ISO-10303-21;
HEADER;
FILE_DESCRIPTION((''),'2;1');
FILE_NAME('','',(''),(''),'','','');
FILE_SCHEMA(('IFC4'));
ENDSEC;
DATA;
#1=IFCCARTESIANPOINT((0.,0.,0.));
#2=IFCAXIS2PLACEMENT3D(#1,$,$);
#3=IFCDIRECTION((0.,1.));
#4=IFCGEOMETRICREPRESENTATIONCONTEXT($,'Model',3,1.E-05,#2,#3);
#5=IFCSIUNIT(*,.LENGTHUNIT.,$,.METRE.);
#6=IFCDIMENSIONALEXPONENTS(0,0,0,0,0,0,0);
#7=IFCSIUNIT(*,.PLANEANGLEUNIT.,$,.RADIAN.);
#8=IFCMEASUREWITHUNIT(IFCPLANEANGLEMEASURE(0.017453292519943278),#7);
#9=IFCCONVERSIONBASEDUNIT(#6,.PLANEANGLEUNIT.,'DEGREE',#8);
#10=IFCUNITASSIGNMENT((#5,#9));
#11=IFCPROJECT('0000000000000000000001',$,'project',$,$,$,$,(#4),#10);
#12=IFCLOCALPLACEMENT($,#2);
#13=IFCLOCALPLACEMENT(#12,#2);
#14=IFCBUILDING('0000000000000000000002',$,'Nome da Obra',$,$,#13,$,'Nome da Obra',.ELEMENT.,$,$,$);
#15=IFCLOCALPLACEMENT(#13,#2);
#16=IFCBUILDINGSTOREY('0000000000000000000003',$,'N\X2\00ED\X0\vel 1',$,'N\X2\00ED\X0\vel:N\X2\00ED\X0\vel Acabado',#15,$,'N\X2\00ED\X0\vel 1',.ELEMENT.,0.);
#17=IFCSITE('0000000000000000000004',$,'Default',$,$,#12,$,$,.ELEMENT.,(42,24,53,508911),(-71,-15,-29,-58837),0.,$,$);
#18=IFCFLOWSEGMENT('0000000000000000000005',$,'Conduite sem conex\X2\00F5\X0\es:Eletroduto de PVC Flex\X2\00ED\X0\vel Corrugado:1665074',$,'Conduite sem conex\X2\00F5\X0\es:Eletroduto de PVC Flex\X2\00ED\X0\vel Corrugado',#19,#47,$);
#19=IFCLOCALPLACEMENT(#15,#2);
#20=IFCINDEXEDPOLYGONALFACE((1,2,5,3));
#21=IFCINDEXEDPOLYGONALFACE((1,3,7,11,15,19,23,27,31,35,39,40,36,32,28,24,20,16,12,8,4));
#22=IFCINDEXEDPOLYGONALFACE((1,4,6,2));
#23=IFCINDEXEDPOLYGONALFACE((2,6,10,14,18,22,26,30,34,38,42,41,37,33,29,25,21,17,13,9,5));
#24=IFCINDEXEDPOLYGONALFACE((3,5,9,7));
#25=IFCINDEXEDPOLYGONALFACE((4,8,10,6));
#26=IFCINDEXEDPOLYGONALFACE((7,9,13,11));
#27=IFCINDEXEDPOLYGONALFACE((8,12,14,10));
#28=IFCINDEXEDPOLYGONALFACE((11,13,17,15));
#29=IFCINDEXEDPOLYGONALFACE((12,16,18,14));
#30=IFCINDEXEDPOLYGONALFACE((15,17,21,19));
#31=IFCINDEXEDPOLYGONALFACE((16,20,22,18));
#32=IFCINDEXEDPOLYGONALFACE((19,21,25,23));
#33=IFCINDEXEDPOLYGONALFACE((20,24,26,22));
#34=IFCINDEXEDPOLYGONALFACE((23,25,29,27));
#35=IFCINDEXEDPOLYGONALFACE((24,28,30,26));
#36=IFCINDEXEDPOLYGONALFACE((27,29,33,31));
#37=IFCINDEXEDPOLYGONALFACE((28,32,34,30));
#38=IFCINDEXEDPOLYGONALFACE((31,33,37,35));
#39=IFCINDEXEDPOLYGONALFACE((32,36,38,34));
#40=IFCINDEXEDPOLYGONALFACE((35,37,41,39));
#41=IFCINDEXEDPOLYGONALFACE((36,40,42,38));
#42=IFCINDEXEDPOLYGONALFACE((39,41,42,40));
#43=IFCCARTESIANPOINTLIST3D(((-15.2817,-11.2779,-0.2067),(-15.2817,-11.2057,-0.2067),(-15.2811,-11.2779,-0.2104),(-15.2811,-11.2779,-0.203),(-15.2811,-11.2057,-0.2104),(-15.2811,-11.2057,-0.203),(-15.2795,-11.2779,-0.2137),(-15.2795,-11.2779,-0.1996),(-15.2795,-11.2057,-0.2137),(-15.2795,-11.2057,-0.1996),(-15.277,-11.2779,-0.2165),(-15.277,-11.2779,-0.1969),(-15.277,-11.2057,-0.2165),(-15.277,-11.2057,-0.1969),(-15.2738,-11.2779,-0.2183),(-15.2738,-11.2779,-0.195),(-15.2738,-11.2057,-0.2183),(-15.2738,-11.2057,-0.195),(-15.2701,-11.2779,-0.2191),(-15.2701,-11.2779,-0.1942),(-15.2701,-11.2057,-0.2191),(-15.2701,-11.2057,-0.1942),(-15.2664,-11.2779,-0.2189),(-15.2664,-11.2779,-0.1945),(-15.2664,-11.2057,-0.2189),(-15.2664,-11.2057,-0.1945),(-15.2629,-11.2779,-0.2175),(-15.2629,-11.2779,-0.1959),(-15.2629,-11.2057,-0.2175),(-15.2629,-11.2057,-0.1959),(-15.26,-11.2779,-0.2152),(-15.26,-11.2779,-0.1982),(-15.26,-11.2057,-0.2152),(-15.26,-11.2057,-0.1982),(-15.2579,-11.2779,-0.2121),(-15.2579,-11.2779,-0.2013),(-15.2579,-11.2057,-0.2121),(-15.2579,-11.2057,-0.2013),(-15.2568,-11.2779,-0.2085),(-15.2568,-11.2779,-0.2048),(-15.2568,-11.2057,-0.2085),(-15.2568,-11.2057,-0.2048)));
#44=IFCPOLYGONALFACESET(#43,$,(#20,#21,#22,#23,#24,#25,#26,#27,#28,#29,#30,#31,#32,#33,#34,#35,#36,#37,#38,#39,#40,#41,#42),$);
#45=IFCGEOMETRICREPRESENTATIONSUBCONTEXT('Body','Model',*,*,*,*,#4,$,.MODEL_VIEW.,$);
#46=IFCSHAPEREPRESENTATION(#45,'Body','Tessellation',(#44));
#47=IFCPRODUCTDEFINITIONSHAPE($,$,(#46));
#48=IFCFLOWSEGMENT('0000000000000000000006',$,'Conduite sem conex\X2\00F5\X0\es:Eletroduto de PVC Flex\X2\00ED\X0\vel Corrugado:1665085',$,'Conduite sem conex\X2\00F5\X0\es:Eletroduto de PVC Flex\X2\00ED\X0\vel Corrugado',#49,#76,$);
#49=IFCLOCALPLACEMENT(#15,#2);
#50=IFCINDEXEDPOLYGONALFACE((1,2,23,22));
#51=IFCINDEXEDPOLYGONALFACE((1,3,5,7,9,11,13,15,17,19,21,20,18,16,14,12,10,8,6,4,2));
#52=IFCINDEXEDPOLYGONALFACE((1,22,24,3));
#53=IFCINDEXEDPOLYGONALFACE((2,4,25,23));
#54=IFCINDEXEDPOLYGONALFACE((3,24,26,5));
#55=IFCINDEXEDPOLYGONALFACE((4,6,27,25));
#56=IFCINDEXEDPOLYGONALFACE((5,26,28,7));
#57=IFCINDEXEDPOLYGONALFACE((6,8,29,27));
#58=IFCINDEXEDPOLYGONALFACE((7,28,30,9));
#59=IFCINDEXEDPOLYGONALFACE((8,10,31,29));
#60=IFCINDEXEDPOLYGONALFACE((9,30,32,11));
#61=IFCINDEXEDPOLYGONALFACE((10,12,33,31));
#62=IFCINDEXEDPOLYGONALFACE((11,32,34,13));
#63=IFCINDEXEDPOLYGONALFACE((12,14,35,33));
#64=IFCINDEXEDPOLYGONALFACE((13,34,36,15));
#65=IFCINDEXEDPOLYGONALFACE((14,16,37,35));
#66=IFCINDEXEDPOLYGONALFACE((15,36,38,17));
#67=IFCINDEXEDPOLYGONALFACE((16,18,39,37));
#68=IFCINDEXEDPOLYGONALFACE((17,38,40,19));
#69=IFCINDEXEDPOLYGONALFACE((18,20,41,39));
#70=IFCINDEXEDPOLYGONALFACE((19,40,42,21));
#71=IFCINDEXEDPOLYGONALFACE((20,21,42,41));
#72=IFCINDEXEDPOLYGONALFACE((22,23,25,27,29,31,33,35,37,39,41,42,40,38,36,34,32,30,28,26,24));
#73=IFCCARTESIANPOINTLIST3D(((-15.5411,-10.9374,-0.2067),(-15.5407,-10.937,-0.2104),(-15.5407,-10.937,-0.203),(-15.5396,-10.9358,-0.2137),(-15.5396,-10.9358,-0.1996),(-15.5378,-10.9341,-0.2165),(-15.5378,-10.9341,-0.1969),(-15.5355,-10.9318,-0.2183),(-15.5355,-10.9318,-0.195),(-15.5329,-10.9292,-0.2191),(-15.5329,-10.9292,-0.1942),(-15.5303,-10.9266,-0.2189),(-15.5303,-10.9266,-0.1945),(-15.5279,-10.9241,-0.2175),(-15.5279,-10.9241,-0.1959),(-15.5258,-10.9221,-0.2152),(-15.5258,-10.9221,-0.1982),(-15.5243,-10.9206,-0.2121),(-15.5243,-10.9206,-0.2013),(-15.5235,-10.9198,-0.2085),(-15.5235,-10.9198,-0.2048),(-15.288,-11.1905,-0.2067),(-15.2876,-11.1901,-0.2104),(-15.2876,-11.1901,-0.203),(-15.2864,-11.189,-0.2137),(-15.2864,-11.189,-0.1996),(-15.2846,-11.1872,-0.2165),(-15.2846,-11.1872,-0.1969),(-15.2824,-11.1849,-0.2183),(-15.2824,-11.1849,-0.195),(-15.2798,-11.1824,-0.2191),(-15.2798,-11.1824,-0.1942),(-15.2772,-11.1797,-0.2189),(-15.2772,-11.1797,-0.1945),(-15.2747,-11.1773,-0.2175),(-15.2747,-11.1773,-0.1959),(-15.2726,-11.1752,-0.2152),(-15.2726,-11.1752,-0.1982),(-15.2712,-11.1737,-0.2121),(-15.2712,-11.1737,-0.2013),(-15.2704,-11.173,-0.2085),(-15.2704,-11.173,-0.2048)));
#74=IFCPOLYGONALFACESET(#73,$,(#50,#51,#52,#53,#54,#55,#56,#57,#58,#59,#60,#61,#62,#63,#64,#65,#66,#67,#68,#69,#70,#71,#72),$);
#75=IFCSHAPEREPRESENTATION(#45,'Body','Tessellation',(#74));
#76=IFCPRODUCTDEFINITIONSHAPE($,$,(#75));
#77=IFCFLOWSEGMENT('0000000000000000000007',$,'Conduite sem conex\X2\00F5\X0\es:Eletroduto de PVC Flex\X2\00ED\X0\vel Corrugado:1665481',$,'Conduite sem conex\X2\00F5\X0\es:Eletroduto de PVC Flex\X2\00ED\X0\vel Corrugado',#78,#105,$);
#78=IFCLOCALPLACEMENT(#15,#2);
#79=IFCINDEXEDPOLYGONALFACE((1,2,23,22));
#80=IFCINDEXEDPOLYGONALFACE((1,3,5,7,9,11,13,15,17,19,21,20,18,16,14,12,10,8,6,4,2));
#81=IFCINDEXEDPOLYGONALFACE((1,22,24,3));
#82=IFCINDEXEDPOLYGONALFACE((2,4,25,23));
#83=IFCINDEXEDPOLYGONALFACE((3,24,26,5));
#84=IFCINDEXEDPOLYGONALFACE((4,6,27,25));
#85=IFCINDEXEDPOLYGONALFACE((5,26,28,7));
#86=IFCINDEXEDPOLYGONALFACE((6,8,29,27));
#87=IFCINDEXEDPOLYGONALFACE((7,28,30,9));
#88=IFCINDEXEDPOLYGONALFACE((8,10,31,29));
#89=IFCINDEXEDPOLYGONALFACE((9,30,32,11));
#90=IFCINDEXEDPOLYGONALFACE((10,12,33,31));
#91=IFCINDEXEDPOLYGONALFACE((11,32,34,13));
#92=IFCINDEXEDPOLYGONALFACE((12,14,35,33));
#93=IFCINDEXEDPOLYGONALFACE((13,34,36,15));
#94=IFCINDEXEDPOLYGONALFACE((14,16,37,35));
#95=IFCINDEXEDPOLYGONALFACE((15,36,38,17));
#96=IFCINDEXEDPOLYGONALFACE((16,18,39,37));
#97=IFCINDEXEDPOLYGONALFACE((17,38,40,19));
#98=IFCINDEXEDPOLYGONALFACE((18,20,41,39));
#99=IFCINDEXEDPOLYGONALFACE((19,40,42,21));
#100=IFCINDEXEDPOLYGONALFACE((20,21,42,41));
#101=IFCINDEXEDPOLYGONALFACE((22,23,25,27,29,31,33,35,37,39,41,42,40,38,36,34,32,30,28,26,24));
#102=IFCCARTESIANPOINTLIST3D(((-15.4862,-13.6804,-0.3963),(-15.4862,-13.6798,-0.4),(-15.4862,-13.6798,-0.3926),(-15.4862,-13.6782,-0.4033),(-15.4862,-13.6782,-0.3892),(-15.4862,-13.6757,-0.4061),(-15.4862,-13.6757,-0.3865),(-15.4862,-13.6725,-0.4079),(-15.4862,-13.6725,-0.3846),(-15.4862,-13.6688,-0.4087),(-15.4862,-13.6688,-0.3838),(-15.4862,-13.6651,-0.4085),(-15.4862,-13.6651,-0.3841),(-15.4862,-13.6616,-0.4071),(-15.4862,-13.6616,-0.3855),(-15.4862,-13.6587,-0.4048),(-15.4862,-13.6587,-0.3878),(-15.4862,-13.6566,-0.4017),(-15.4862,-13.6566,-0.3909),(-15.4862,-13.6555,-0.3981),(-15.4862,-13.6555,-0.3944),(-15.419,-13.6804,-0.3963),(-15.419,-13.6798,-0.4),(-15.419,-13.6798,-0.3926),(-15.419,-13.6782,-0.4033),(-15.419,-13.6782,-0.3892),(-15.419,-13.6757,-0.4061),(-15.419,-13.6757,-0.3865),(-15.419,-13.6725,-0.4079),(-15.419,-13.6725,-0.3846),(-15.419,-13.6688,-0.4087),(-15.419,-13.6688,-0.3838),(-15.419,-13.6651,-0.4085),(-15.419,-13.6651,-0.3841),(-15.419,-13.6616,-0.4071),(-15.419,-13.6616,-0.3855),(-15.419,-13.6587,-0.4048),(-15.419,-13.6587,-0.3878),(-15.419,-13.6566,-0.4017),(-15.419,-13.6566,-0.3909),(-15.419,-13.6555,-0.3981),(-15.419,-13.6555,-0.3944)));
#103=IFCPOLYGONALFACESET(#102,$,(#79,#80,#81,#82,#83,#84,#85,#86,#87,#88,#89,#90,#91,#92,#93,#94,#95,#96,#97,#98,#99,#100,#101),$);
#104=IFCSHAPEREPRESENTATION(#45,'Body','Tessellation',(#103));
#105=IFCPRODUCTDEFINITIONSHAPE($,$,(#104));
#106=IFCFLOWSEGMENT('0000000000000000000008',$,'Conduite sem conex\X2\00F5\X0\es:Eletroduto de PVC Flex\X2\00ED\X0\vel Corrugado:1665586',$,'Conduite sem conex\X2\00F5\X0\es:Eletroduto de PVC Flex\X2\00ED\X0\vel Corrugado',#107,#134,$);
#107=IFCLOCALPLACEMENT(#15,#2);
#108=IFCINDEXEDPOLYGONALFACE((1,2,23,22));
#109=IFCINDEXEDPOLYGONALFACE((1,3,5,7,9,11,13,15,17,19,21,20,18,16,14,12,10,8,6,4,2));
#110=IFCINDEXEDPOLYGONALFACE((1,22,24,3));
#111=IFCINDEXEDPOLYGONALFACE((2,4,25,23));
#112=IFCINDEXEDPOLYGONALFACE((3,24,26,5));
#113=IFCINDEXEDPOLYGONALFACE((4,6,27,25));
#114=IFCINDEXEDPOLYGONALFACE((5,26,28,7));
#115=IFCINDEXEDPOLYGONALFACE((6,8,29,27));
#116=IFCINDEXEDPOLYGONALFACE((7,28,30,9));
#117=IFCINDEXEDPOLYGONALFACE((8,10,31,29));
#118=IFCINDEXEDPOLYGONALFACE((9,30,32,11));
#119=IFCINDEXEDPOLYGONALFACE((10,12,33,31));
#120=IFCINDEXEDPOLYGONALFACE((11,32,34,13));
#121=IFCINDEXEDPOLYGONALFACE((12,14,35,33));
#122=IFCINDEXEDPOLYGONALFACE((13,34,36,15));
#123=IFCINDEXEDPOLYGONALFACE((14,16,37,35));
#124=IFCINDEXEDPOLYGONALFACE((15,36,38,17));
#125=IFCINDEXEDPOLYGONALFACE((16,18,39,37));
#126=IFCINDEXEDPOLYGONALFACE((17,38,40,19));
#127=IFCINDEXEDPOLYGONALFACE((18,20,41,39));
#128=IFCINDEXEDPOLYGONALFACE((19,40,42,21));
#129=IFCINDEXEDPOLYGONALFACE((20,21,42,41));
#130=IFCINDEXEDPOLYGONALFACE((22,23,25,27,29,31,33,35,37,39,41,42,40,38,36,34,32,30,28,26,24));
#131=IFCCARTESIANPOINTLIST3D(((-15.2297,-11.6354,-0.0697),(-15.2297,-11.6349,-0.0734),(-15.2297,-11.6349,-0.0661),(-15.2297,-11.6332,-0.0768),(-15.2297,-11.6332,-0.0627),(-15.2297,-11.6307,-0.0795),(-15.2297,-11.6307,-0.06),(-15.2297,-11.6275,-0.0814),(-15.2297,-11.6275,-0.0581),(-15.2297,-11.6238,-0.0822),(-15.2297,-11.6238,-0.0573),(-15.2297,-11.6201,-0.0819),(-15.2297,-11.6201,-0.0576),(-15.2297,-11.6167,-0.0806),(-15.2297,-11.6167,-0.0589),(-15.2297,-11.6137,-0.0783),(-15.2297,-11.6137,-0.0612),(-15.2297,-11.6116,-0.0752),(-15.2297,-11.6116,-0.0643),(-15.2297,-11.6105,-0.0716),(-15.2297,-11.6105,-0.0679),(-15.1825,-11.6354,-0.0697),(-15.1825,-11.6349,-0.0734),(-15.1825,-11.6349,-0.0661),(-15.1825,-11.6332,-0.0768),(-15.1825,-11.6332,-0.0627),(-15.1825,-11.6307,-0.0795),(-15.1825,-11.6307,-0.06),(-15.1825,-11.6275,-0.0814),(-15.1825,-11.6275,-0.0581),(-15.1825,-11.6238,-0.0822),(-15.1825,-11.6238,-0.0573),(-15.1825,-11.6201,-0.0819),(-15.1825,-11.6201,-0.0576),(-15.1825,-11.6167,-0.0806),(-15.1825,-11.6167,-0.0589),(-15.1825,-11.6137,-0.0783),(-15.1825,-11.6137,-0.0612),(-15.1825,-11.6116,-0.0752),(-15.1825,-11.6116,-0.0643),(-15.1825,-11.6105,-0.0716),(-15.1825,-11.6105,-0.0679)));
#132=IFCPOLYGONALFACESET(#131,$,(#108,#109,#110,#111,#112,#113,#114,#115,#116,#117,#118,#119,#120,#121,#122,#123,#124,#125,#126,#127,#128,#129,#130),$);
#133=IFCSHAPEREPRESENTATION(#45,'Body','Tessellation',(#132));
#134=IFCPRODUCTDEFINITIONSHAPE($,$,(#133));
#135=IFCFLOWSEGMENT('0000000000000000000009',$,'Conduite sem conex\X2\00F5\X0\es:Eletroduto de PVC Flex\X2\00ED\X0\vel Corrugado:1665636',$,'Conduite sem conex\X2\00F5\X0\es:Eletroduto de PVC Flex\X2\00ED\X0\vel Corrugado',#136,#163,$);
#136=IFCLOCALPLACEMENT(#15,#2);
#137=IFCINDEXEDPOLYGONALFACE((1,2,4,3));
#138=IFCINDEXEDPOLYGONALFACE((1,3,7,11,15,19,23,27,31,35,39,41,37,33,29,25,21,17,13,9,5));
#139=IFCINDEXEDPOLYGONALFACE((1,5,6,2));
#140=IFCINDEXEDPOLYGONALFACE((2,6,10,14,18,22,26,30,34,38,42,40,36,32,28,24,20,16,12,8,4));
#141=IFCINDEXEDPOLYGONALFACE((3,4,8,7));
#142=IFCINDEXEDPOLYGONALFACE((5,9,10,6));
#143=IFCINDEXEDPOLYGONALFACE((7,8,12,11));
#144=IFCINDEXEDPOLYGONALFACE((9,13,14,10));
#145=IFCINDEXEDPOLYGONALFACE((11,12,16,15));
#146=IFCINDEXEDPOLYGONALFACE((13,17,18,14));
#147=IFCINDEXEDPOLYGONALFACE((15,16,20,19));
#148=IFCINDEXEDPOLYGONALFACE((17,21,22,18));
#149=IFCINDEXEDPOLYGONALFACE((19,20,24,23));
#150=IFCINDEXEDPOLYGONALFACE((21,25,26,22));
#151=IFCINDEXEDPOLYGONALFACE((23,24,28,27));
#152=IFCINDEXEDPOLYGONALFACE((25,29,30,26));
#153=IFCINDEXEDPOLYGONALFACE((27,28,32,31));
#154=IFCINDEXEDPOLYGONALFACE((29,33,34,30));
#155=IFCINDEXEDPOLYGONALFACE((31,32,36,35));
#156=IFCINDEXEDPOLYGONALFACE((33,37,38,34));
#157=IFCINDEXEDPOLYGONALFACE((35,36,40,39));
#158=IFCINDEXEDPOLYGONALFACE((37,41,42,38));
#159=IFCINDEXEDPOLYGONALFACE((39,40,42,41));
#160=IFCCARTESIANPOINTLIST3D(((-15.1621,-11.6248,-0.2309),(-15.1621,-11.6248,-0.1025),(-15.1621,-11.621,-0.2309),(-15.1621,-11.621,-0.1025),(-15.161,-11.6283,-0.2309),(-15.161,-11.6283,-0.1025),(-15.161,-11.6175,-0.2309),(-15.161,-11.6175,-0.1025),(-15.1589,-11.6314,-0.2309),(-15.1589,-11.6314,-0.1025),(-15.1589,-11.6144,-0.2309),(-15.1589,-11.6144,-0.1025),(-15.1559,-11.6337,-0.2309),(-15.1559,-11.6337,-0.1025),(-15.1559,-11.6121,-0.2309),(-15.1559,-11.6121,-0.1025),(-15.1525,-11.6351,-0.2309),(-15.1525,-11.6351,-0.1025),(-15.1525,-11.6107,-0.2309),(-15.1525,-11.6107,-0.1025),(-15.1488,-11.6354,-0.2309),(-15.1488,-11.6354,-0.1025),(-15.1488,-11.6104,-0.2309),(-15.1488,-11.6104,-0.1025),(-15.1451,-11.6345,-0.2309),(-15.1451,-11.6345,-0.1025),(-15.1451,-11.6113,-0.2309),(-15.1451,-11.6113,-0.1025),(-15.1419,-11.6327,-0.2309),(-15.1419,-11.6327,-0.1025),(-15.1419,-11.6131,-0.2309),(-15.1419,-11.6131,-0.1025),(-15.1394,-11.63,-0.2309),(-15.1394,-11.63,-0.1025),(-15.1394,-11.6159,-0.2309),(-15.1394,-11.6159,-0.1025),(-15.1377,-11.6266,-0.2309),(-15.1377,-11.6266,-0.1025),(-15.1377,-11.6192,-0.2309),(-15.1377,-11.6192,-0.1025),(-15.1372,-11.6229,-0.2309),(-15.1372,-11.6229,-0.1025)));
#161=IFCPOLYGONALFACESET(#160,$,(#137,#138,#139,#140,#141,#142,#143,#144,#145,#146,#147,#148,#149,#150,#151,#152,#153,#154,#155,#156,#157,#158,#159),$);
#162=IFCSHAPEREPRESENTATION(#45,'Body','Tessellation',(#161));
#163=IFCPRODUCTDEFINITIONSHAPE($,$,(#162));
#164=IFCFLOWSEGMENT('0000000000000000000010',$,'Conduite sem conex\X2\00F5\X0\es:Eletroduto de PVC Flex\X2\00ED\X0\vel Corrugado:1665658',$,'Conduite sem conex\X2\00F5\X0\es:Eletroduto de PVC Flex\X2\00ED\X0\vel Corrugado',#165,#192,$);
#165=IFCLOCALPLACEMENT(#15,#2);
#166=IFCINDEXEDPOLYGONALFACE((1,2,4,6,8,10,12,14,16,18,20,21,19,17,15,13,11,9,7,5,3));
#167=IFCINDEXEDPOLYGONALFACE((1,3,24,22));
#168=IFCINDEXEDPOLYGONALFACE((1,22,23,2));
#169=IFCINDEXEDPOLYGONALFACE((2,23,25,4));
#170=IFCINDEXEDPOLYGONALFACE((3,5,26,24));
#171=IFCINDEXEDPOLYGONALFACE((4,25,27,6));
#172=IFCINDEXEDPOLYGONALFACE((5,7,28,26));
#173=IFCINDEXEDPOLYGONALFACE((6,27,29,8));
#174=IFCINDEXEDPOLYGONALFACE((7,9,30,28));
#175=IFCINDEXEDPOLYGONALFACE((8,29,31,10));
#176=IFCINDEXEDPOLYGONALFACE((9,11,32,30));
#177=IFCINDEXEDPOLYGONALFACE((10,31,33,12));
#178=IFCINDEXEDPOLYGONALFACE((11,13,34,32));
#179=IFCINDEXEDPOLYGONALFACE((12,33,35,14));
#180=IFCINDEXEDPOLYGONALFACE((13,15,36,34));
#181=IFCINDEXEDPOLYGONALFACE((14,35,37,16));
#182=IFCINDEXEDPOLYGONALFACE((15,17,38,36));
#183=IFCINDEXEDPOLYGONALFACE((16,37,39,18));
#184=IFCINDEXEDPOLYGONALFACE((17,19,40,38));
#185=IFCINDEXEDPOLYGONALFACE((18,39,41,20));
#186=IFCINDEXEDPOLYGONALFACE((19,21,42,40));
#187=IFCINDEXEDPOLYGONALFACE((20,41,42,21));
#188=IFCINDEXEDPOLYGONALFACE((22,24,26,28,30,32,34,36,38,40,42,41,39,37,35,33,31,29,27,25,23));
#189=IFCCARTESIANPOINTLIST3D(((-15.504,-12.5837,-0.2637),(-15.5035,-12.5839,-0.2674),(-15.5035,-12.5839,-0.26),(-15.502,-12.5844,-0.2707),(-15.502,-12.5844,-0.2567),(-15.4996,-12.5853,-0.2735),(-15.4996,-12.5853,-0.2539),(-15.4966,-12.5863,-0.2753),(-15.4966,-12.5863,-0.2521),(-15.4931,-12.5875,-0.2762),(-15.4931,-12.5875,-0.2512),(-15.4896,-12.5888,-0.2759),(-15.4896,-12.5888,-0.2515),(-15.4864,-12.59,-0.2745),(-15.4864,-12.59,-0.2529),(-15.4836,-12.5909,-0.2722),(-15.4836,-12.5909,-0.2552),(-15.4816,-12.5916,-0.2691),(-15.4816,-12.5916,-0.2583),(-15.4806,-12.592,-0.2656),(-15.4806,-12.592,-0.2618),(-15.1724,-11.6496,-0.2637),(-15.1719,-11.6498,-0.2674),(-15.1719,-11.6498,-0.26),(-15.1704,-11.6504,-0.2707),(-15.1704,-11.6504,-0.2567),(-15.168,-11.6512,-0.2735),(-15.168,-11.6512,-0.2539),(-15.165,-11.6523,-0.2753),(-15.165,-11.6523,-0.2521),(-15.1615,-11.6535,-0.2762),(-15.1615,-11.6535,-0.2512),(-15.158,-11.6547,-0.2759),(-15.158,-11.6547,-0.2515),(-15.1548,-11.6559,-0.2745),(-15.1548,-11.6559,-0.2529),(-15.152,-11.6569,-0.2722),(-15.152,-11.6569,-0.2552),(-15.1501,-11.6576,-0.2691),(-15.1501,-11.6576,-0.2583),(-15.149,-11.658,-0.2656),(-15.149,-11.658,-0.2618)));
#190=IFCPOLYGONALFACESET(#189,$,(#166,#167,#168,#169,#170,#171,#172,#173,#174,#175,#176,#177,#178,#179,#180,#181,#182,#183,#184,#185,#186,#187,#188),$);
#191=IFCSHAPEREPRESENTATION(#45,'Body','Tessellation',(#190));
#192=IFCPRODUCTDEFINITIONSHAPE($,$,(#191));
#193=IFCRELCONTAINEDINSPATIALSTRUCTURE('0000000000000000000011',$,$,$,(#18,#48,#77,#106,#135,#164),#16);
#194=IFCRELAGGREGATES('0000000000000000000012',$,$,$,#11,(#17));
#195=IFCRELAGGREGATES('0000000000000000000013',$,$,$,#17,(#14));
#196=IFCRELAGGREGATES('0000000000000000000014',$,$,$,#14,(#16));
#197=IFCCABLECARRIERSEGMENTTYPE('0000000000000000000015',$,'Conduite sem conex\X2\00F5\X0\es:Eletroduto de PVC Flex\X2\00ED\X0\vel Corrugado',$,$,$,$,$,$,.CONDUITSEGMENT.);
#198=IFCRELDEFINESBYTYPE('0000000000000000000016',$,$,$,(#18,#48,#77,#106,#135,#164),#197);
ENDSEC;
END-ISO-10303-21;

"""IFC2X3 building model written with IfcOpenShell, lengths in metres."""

from ifc_helpers import new_model, entity, si_unit, converted_unit, direction, frame, frame_2d, origin, origin_2d_with_axis, place, context, subcontext, project, spatial, circle, extrude, type_object, element, save


model = new_model("IFC2X3")

# Units and contexts
model_context = context("Model", 3, precision=1e-05, world=origin(), true_north=direction((0.0, 1.0)))
body_context = subcontext(model_context, "Body", "Model", "MODEL_VIEW")
ifc_project = project(units=[si_unit("LENGTHUNIT", "METRE"), converted_unit("PLANEANGLEUNIT", "DEGREE", entity("IfcPlaneAngleMeasure", 0.017453292519943278), si_unit("PLANEANGLEUNIT", "RADIAN"), dimensions=[0, 0, 0, 0, 0, 0, 0])], contexts=[model_context])

# Site, building, storey
site_placement = place(None, origin())
site = spatial("IfcSite", under=ifc_project, at=site_placement, Name="Default", CompositionType="ELEMENT", RefLatitude=(42, 24, 53, 508911), RefLongitude=(-71, -15, -29, -58837), RefElevation=0.0)
building_placement = place(site_placement, origin())
building = spatial("IfcBuilding", under=site, at=building_placement, Name="Nome da Obra", LongName="Nome da Obra", CompositionType="ELEMENT")
storey_placement = place(building_placement, origin())
storey = spatial("IfcBuildingStorey", under=building, at=storey_placement, Name="Nível 1", ObjectType="Nível:Nível Acabado", LongName="Nível 1", CompositionType="ELEMENT", Elevation=0.0)

# Flow segments
cable_carrier_segment_type = type_object("IfcCableCarrierSegmentType", Name="Conduite sem conexões:Eletroduto de PVC Flexível Corrugado", PredefinedType="CONDUITSEGMENT")
flow_segment_1_placement = place(storey_placement, origin())
element("IfcFlowSegment", 1, at=flow_segment_1_placement, inside=storey, type_object=cable_carrier_segment_type, Name="Conduite sem conexões:Eletroduto de PVC Flexível Corrugado:1665074", ObjectType="Conduite sem conexões:Eletroduto de PVC Flexível Corrugado", context=body_context, shape_type="SweptSolid", body=[
    extrude(circle(Radius=0.0125, at=origin_2d_with_axis()), frame((-15.2692, -11.2779, -0.2067), z_axis=(0.0, 1.0, 0.0), x_axis=(-1.0, 0.0, 0.0)), (0.0, 0.0, 1.0), 0.0722),
])
flow_segment_2_placement = place(storey_placement, origin())
element("IfcFlowSegment", 2, at=flow_segment_2_placement, inside=storey, type_object=cable_carrier_segment_type, Name="Conduite sem conexões:Eletroduto de PVC Flexível Corrugado:1665085", ObjectType="Conduite sem conexões:Eletroduto de PVC Flexível Corrugado", context=body_context, shape_type="SweptSolid", body=[
    extrude(circle(Radius=0.0125, at=origin_2d_with_axis()), frame((-15.5323, -10.9285, -0.2067), z_axis=(0.707107, -0.707107, 0.0), x_axis=(-0.707107, -0.707107, 0.0)), (0.0, 0.0, 1.0), 0.358),
])
flow_segment_3_placement = place(storey_placement, origin())
element("IfcFlowSegment", 3, at=flow_segment_3_placement, inside=storey, type_object=cable_carrier_segment_type, Name="Conduite sem conexões:Eletroduto de PVC Flexível Corrugado:1665481", ObjectType="Conduite sem conexões:Eletroduto de PVC Flexível Corrugado", context=body_context, shape_type="SweptSolid", body=[
    extrude(circle(Radius=0.0125, at=origin_2d_with_axis()), frame((-15.4862, -13.6679, -0.3963), z_axis=(1.0, 0.0, 0.0), x_axis=(0.0, -1.0, 0.0)), (0.0, 0.0, 1.0), 0.0672),
])
flow_segment_4_placement = place(storey_placement, origin())
element("IfcFlowSegment", 4, at=flow_segment_4_placement, inside=storey, type_object=cable_carrier_segment_type, Name="Conduite sem conexões:Eletroduto de PVC Flexível Corrugado:1665586", ObjectType="Conduite sem conexões:Eletroduto de PVC Flexível Corrugado", context=body_context, shape_type="SweptSolid", body=[
    extrude(circle(Radius=0.0125, at=frame_2d((0.0, 0.0), x_axis=(1.0, 0.0))), frame((-15.2297, -11.6229, -0.0697), z_axis=(1.0, 0.0, 0.0), x_axis=(0.0, -1.0, 0.0)), (0.0, 0.0, 1.0), 0.0472),
])
flow_segment_5_placement = place(storey_placement, origin())
element("IfcFlowSegment", 5, at=flow_segment_5_placement, inside=storey, type_object=cable_carrier_segment_type, Name="Conduite sem conexões:Eletroduto de PVC Flexível Corrugado:1665636", ObjectType="Conduite sem conexões:Eletroduto de PVC Flexível Corrugado", context=body_context, shape_type="SweptSolid", body=[
    extrude(circle(Radius=0.0125, at=origin_2d_with_axis()), frame((-15.1497, -11.6229, -0.2309)), (0.0, 0.0, 1.0), 0.1284),
])
flow_segment_6_placement = place(storey_placement, origin())
element("IfcFlowSegment", 6, at=flow_segment_6_placement, inside=storey, type_object=cable_carrier_segment_type, Name="Conduite sem conexões:Eletroduto de PVC Flexível Corrugado:1665658", ObjectType="Conduite sem conexões:Eletroduto de PVC Flexível Corrugado", context=body_context, shape_type="SweptSolid", body=[
    extrude(circle(Radius=0.0125, at=origin_2d_with_axis()), frame((-15.4923, -12.5879, -0.2637), z_axis=(0.334557, 0.942376, 0.0), x_axis=(-0.942376, 0.334557, 0.0)), (0.0, 0.0, 1.0), 0.9912),
])

save(model, "model.ifc")
